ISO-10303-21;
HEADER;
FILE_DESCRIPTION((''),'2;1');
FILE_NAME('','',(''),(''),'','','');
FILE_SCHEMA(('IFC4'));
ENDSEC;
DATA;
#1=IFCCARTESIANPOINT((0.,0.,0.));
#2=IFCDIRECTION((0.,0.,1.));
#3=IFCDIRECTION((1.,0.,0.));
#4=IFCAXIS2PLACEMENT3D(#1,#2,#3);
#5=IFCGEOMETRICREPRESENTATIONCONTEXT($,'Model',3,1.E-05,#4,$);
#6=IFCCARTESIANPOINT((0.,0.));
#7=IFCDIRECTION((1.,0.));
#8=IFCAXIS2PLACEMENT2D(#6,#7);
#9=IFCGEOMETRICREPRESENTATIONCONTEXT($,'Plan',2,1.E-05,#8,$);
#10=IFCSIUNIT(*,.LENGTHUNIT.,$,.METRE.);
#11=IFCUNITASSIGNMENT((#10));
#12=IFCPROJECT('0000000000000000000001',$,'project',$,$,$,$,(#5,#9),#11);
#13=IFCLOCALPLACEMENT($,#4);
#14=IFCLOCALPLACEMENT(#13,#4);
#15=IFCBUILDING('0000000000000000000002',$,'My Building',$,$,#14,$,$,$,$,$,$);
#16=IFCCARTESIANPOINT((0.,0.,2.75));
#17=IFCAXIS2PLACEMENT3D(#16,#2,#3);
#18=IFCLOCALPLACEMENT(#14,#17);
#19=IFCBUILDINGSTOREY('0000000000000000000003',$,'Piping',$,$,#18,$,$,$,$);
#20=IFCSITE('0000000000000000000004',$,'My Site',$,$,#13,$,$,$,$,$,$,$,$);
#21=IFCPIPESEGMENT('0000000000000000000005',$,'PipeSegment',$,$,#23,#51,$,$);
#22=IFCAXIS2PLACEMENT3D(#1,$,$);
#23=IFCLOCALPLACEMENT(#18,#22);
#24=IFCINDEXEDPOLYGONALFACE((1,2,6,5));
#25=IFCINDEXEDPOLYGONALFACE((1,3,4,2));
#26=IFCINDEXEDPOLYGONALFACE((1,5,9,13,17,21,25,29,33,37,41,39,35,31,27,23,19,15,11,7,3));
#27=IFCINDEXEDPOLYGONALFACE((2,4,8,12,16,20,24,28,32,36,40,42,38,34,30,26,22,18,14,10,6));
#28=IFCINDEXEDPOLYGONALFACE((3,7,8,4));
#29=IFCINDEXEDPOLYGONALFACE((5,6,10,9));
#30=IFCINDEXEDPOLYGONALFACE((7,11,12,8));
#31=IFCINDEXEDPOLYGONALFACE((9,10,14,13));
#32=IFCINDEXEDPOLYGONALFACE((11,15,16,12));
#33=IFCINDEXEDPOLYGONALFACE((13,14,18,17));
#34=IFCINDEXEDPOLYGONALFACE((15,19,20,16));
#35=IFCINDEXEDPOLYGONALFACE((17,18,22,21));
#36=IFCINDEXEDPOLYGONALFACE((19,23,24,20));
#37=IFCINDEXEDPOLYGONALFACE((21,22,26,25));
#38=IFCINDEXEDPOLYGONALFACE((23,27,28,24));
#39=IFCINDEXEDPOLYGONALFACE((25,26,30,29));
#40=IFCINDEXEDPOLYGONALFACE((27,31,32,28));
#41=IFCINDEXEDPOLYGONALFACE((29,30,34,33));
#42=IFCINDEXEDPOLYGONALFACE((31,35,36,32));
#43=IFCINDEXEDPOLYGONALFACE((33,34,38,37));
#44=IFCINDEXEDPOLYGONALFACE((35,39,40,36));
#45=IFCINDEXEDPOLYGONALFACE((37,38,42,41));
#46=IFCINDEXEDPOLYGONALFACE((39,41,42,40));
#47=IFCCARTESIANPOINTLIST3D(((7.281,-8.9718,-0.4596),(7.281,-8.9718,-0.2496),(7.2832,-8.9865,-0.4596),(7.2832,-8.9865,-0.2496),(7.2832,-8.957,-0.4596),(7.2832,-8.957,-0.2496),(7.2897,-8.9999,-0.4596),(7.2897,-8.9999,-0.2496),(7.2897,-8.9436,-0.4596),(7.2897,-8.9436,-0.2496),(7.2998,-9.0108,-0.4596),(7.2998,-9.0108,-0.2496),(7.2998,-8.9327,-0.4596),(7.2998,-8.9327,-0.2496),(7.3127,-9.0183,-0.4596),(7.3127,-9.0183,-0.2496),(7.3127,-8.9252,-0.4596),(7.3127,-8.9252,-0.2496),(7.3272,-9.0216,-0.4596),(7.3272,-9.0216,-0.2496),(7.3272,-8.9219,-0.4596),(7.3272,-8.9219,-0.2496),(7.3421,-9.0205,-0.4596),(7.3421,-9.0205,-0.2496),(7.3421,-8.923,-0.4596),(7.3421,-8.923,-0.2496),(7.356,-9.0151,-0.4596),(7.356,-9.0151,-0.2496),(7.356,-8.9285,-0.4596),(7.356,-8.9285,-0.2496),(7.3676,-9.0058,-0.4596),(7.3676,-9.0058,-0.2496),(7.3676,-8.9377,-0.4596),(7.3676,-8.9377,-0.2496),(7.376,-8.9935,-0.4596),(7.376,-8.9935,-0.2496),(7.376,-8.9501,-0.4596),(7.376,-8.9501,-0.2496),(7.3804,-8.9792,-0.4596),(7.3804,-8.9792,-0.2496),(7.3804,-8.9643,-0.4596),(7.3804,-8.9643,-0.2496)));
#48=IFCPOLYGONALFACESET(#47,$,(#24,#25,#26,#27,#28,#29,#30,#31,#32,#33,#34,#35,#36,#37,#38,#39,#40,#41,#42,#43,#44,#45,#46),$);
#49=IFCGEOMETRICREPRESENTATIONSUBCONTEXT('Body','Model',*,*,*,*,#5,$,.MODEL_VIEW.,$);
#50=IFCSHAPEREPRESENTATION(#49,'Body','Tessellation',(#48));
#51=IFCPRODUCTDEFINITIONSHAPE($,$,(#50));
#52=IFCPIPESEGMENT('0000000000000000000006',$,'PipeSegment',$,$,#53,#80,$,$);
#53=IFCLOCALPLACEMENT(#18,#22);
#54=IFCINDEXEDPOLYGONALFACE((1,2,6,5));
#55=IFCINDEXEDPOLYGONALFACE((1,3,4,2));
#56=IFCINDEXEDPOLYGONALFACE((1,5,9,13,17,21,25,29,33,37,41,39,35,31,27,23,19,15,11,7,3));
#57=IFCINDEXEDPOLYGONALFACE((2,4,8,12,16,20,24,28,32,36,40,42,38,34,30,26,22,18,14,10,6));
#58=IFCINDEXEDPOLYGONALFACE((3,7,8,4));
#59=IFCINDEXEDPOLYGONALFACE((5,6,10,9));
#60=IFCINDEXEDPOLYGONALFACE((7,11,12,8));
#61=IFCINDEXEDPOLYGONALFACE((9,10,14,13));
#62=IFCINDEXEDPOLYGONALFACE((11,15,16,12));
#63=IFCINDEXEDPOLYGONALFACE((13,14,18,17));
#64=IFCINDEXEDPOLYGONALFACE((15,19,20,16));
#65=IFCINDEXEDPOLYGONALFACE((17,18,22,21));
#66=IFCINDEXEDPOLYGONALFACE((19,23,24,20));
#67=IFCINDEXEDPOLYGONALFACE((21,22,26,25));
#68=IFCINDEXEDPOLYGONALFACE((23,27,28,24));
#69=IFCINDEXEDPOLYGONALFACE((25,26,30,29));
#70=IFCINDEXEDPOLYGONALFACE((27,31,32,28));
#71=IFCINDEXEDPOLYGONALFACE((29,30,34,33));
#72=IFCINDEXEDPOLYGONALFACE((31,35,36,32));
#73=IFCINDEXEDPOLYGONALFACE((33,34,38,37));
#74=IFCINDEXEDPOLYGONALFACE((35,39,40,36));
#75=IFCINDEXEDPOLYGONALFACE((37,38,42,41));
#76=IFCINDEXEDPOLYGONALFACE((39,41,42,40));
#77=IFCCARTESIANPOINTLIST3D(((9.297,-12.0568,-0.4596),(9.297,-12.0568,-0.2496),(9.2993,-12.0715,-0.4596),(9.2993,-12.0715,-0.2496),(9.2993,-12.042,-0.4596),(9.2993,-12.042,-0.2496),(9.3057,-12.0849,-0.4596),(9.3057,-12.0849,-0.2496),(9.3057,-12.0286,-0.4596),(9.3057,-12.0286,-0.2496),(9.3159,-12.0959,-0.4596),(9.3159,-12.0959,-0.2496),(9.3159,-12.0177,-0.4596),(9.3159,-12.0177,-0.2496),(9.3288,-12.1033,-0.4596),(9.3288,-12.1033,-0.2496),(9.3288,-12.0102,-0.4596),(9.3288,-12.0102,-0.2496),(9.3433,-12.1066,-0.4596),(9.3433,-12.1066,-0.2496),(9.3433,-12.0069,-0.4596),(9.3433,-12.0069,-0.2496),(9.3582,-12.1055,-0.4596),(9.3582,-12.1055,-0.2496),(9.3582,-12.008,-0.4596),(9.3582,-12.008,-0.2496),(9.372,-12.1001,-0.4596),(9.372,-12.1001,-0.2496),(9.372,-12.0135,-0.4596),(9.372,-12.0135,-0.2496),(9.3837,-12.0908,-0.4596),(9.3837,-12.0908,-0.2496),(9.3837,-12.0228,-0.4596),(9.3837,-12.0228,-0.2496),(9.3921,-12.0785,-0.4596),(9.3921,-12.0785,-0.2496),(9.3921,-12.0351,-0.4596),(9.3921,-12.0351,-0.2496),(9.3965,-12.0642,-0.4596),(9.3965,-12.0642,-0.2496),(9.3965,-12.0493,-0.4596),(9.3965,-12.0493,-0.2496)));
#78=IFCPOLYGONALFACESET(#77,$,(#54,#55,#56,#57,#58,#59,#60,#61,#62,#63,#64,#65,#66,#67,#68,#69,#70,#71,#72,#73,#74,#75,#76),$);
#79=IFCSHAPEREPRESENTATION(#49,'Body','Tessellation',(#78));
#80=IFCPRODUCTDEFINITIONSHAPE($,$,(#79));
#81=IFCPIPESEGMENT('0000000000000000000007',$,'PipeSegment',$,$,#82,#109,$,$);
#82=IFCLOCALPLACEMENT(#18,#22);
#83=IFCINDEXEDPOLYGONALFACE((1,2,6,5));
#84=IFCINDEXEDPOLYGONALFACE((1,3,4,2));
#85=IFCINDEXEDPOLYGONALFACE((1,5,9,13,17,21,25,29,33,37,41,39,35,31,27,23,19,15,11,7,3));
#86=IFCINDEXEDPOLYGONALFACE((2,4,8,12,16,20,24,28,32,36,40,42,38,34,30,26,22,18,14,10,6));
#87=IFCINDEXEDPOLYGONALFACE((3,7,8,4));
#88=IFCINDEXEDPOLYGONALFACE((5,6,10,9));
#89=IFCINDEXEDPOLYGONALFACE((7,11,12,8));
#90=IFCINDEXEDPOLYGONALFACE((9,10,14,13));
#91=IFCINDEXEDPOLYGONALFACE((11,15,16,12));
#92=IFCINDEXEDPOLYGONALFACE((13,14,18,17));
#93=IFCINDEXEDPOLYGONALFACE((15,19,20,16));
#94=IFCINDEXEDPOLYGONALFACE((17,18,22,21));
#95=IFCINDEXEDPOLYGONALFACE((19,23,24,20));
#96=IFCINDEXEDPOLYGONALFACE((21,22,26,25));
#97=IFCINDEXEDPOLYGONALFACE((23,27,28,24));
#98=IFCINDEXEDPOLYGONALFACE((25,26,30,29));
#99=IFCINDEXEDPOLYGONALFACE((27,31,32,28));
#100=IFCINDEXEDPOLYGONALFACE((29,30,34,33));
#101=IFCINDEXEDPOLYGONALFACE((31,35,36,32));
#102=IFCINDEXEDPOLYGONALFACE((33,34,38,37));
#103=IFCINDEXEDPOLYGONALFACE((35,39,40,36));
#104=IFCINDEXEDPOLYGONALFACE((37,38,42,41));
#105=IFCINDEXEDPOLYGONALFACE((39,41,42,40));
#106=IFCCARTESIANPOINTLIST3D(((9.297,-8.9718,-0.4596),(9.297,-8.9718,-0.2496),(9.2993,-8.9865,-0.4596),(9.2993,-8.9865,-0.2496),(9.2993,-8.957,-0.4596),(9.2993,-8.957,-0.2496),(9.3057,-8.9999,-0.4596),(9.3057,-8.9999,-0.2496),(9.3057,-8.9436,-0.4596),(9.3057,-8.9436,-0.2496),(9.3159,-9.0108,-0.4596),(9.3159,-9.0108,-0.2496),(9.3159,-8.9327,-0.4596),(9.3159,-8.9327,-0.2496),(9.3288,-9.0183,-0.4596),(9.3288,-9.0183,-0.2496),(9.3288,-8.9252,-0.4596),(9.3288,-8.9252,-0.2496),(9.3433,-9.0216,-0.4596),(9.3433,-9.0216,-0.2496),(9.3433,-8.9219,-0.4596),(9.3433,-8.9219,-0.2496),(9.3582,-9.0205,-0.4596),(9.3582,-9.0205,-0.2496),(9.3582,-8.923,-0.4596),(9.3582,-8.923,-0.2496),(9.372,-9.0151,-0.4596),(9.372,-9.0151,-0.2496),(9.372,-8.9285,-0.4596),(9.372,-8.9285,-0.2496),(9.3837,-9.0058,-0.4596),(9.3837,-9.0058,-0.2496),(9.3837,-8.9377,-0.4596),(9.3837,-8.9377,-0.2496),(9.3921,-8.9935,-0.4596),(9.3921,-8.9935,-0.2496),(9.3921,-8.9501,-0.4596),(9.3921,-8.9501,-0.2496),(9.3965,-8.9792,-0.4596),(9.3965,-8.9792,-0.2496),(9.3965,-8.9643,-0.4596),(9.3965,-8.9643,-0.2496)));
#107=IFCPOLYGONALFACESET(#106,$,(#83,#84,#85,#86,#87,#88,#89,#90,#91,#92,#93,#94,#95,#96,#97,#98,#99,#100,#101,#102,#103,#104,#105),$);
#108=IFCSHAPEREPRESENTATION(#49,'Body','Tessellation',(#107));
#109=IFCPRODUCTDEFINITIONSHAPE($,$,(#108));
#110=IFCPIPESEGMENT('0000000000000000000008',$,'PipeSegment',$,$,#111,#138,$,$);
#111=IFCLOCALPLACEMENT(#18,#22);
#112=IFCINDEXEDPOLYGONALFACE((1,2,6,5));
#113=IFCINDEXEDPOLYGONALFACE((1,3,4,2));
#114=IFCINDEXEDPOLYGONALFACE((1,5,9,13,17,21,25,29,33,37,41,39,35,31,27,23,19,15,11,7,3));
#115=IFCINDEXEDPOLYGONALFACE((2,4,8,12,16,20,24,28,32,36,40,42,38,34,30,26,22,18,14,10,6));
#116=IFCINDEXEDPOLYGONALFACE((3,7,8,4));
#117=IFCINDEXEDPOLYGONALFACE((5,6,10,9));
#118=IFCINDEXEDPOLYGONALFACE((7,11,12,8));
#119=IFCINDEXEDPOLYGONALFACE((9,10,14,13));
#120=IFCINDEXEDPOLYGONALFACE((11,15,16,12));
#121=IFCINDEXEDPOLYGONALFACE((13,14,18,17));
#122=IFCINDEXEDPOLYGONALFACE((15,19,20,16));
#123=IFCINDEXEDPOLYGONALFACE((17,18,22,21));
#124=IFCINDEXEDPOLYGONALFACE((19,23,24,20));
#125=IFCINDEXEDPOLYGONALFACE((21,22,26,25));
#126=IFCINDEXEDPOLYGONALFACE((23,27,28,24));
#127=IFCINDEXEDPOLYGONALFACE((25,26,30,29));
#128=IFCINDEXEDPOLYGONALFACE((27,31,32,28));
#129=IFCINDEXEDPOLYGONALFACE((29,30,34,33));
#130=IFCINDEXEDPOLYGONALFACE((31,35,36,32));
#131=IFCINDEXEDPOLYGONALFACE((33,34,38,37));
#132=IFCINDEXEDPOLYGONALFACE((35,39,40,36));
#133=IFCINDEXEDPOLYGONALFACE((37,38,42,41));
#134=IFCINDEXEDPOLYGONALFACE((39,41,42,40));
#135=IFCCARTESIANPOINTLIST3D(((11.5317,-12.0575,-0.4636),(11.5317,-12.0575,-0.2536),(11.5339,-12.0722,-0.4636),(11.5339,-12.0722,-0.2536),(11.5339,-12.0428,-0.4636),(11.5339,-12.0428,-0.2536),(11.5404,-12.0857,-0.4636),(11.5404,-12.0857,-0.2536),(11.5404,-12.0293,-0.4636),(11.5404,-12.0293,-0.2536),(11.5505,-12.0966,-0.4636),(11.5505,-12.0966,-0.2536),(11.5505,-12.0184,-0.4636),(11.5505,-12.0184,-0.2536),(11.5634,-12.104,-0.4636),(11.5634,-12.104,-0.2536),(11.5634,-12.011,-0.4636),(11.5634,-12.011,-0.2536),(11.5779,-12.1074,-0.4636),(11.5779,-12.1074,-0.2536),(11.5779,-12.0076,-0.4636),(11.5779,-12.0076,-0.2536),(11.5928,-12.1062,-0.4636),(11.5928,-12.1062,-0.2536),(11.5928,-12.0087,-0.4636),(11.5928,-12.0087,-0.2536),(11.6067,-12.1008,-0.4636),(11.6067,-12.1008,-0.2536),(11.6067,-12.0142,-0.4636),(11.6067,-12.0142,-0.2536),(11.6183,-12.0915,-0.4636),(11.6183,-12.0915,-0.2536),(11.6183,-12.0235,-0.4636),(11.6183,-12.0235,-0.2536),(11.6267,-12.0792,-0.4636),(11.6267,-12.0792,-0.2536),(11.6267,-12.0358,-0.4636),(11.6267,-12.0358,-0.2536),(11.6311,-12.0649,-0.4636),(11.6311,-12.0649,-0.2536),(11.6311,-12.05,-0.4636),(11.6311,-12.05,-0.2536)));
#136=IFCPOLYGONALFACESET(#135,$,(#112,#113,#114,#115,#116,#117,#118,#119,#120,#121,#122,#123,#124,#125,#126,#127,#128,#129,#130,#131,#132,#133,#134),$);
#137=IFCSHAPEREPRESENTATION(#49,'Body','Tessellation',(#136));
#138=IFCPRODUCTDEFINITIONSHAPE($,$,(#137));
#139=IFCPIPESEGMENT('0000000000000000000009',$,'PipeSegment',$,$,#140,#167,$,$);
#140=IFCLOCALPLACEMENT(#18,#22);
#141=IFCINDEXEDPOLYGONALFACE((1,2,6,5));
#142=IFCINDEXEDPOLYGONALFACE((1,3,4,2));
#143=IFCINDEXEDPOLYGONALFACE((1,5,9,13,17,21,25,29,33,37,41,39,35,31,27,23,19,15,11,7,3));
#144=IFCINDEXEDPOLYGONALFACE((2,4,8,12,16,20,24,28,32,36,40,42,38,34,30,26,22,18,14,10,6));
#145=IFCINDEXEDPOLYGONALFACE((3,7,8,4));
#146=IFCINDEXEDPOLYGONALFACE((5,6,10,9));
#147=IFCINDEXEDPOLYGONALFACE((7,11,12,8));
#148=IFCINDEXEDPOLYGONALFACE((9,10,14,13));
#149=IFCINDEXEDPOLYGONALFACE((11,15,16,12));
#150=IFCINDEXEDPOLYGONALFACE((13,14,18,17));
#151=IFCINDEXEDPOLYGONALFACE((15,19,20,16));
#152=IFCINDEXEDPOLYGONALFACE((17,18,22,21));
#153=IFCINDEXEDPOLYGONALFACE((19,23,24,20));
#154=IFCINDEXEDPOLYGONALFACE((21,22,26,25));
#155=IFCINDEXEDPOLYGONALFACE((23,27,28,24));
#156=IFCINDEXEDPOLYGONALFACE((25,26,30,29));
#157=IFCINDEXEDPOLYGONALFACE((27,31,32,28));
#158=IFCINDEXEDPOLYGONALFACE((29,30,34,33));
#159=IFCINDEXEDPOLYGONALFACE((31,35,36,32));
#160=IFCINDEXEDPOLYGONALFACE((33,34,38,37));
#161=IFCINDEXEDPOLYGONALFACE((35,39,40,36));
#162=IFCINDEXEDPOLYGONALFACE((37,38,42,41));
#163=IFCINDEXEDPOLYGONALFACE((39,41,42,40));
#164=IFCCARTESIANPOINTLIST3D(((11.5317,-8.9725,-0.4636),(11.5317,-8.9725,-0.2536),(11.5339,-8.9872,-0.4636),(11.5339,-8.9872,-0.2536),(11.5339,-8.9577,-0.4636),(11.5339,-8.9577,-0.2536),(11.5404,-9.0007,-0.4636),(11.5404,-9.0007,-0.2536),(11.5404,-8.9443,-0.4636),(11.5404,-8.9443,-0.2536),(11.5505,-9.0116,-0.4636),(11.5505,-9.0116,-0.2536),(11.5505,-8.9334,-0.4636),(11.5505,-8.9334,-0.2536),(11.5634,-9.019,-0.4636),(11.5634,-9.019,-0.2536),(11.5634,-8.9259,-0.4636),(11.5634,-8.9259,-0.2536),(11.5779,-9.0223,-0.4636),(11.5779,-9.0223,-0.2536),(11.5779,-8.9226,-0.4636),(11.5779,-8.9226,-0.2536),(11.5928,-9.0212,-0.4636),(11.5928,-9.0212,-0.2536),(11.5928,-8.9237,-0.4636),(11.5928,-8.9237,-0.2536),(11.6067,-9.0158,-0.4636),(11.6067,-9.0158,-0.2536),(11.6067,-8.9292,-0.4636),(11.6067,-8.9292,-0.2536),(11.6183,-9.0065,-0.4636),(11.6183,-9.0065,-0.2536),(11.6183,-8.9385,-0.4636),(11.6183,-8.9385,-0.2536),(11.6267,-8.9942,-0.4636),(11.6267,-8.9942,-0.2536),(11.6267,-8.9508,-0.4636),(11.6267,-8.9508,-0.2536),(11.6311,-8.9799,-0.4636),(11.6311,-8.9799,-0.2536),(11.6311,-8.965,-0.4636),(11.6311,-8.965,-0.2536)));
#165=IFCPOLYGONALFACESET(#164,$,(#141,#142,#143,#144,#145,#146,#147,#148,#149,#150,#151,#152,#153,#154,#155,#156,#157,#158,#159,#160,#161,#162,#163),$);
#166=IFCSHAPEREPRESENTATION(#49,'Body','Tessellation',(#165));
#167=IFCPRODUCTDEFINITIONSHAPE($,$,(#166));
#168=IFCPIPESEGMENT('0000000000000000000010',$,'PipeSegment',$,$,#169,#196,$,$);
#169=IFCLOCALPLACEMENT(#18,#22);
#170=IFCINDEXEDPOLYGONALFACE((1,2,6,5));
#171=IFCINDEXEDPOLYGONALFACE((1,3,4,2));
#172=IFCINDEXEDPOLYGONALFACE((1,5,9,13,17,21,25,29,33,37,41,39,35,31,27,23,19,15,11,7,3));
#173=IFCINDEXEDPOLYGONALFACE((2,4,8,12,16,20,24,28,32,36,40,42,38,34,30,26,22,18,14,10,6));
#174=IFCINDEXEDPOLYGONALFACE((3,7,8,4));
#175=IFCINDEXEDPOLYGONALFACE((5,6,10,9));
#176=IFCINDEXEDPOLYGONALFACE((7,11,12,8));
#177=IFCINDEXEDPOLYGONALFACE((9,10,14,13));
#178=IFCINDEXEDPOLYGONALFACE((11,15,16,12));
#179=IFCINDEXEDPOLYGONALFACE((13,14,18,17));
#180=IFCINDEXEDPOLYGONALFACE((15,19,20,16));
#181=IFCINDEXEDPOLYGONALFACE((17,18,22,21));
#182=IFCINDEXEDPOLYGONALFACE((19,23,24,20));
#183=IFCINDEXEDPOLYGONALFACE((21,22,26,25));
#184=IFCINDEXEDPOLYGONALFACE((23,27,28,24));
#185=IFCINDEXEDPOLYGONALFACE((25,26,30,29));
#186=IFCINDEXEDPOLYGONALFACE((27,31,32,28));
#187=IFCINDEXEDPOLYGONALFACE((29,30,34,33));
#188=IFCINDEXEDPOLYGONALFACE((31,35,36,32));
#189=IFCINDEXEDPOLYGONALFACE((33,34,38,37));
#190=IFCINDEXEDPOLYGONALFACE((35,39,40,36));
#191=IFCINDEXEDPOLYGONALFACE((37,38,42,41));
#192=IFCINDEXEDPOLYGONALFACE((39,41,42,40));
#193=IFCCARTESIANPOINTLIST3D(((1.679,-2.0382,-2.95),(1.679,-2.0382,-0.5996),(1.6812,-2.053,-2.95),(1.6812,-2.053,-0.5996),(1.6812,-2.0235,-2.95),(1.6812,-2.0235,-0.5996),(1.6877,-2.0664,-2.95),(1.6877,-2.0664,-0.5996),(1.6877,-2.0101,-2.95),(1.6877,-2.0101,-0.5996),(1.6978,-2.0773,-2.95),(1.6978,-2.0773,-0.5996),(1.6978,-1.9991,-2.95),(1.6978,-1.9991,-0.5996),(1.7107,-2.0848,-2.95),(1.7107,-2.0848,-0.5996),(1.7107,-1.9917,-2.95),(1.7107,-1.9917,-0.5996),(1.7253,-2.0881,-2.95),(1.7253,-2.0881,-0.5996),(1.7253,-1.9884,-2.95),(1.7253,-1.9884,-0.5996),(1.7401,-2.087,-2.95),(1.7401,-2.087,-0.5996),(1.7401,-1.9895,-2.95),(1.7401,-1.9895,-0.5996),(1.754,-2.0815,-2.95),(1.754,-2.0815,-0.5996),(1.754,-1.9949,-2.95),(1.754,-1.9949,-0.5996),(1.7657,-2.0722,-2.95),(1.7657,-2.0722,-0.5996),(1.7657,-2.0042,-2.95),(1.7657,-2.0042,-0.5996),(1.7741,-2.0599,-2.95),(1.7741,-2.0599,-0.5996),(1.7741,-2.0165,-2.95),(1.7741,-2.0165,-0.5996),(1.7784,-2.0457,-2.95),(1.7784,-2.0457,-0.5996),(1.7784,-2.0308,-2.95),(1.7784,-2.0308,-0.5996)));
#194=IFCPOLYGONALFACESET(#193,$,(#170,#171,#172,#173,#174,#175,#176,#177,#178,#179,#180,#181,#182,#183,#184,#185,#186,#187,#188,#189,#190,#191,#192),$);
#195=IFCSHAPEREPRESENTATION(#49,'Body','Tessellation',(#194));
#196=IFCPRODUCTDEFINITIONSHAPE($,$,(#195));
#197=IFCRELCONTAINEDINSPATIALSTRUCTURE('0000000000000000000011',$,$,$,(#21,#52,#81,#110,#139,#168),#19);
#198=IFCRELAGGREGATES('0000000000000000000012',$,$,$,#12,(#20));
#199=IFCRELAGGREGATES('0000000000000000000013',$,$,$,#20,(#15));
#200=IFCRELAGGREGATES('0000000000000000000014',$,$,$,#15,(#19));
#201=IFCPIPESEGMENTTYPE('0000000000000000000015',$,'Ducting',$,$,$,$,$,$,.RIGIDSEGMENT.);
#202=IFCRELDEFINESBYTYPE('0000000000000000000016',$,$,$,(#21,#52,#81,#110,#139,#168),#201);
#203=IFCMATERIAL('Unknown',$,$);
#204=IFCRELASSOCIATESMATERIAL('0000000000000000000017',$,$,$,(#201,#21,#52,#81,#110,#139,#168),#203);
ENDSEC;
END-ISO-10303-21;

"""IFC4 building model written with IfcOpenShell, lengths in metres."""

from ifc_helpers import new_model, si_unit, frame, origin_with_axes, origin_2d_with_axis, place, context, subcontext, project, spatial, circle, extrude, material, material_profile, profile_set, profile_usage, type_object, element, save


model = new_model("IFC4")

# Units and contexts
model_context = context("Model", 3, precision=1e-05, world=origin_with_axes())
plan_context = context("Plan", 2, precision=1e-05, world=origin_2d_with_axis())
body_context = subcontext(model_context, "Body", "Model", "MODEL_VIEW")
ifc_project = project(units=[si_unit("LENGTHUNIT", "METRE")], contexts=[model_context, plan_context])

# Site, building, storey
site_placement = place(None, origin_with_axes())
site = spatial("IfcSite", under=ifc_project, at=site_placement, Name="My Site")
building_placement = place(site_placement, origin_with_axes())
building = spatial("IfcBuilding", under=site, at=building_placement, Name="My Building")
storey_placement = place(building_placement, frame((0.0, 0.0, 2.75), z_axis=(0.0, 0.0, 1.0), x_axis=(1.0, 0.0, 0.0)))
storey = spatial("IfcBuildingStorey", under=building, at=storey_placement, Name="Piping")

# Pipe segments
ifc_material = material(Name="Unknown")
ifc_material_profile = material_profile(ifc_material, circle(Radius=0.05))
ifc_profile_set = profile_set([ifc_material_profile])
pipe_segment_type = type_object("IfcPipeSegmentType", Name="Ducting", PredefinedType="RIGIDSEGMENT", material=ifc_profile_set)
ifc_profile_usage_1 = profile_usage(ifc_profile_set, cardinal=4)
pipe_segment_1_placement = place(storey_placement, frame((7.281, -8.9718, -0.2496), z_axis=(0.0, 0.0, -1.0), x_axis=(-1.0, 0.0, 0.0)))
element("IfcPipeSegment", 1, at=pipe_segment_1_placement, inside=storey, type_object=pipe_segment_type, material=ifc_profile_usage_1, Name="PipeSegment", context=body_context, shape_type="SweptSolid", body=[
    extrude(circle(Radius=0.05), frame((-0.05, 0.0, 0.0), z_axis=(0.0, 0.0, 1.0), x_axis=(1.0, 0.0, 0.0)), (0.0, 0.0, 1.0), 0.21),
])
ifc_profile_usage_2 = profile_usage(ifc_profile_set, cardinal=4)
pipe_segment_2_placement = place(storey_placement, frame((9.297, -12.0568, -0.2496), z_axis=(0.0, 0.0, -1.0), x_axis=(-1.0, 0.0, 0.0)))
element("IfcPipeSegment", 2, at=pipe_segment_2_placement, inside=storey, type_object=pipe_segment_type, material=ifc_profile_usage_2, Name="PipeSegment", context=body_context, shape_type="SweptSolid", body=[
    extrude(circle(Radius=0.05), frame((-0.05, 0.0, 0.0), z_axis=(0.0, 0.0, 1.0), x_axis=(1.0, 0.0, 0.0)), (0.0, 0.0, 1.0), 0.21),
])
ifc_profile_usage_3 = profile_usage(ifc_profile_set, cardinal=4)
pipe_segment_3_placement = place(storey_placement, frame((9.297, -8.9718, -0.2496), z_axis=(0.0, 0.0, -1.0), x_axis=(-1.0, 0.0, 0.0)))
element("IfcPipeSegment", 3, at=pipe_segment_3_placement, inside=storey, type_object=pipe_segment_type, material=ifc_profile_usage_3, Name="PipeSegment", context=body_context, shape_type="SweptSolid", body=[
    extrude(circle(Radius=0.05), frame((-0.05, 0.0, 0.0), z_axis=(0.0, 0.0, 1.0), x_axis=(1.0, 0.0, 0.0)), (0.0, 0.0, 1.0), 0.21),
])
ifc_profile_usage_4 = profile_usage(ifc_profile_set, cardinal=4)
pipe_segment_4_placement = place(storey_placement, frame((11.5317, -12.0575, -0.2536), z_axis=(0.0, 0.0, -1.0), x_axis=(-1.0, 0.0, 0.0)))
element("IfcPipeSegment", 4, at=pipe_segment_4_placement, inside=storey, type_object=pipe_segment_type, material=ifc_profile_usage_4, Name="PipeSegment", context=body_context, shape_type="SweptSolid", body=[
    extrude(circle(Radius=0.05), frame((-0.05, 0.0, 0.0), z_axis=(0.0, 0.0, 1.0), x_axis=(1.0, 0.0, 0.0)), (0.0, 0.0, 1.0), 0.21),
])
ifc_profile_usage_5 = profile_usage(ifc_profile_set, cardinal=4)
pipe_segment_5_placement = place(storey_placement, frame((11.5317, -8.9725, -0.2536), z_axis=(0.0, 0.0, -1.0), x_axis=(-1.0, 0.0, 0.0)))
element("IfcPipeSegment", 5, at=pipe_segment_5_placement, inside=storey, type_object=pipe_segment_type, material=ifc_profile_usage_5, Name="PipeSegment", context=body_context, shape_type="SweptSolid", body=[
    extrude(circle(Radius=0.05), frame((-0.05, 0.0, 0.0), z_axis=(0.0, 0.0, 1.0), x_axis=(1.0, 0.0, 0.0)), (0.0, 0.0, 1.0), 0.21),
])
ifc_profile_usage_6 = profile_usage(ifc_profile_set, cardinal=4)
pipe_segment_6_placement = place(storey_placement, frame((1.679, -2.0382, -0.5996), z_axis=(0.0, 0.0, -1.0), x_axis=(-1.0, 0.0, 0.0)))
element("IfcPipeSegment", 6, at=pipe_segment_6_placement, inside=storey, type_object=pipe_segment_type, material=ifc_profile_usage_6, Name="PipeSegment", context=body_context, shape_type="SweptSolid", body=[
    extrude(circle(Radius=0.05), frame((-0.05, 0.0, 0.0), z_axis=(0.0, 0.0, 1.0), x_axis=(1.0, 0.0, 0.0)), (0.0, 0.0, 1.0), 2.3504),
])

save(model, "model.ifc")
